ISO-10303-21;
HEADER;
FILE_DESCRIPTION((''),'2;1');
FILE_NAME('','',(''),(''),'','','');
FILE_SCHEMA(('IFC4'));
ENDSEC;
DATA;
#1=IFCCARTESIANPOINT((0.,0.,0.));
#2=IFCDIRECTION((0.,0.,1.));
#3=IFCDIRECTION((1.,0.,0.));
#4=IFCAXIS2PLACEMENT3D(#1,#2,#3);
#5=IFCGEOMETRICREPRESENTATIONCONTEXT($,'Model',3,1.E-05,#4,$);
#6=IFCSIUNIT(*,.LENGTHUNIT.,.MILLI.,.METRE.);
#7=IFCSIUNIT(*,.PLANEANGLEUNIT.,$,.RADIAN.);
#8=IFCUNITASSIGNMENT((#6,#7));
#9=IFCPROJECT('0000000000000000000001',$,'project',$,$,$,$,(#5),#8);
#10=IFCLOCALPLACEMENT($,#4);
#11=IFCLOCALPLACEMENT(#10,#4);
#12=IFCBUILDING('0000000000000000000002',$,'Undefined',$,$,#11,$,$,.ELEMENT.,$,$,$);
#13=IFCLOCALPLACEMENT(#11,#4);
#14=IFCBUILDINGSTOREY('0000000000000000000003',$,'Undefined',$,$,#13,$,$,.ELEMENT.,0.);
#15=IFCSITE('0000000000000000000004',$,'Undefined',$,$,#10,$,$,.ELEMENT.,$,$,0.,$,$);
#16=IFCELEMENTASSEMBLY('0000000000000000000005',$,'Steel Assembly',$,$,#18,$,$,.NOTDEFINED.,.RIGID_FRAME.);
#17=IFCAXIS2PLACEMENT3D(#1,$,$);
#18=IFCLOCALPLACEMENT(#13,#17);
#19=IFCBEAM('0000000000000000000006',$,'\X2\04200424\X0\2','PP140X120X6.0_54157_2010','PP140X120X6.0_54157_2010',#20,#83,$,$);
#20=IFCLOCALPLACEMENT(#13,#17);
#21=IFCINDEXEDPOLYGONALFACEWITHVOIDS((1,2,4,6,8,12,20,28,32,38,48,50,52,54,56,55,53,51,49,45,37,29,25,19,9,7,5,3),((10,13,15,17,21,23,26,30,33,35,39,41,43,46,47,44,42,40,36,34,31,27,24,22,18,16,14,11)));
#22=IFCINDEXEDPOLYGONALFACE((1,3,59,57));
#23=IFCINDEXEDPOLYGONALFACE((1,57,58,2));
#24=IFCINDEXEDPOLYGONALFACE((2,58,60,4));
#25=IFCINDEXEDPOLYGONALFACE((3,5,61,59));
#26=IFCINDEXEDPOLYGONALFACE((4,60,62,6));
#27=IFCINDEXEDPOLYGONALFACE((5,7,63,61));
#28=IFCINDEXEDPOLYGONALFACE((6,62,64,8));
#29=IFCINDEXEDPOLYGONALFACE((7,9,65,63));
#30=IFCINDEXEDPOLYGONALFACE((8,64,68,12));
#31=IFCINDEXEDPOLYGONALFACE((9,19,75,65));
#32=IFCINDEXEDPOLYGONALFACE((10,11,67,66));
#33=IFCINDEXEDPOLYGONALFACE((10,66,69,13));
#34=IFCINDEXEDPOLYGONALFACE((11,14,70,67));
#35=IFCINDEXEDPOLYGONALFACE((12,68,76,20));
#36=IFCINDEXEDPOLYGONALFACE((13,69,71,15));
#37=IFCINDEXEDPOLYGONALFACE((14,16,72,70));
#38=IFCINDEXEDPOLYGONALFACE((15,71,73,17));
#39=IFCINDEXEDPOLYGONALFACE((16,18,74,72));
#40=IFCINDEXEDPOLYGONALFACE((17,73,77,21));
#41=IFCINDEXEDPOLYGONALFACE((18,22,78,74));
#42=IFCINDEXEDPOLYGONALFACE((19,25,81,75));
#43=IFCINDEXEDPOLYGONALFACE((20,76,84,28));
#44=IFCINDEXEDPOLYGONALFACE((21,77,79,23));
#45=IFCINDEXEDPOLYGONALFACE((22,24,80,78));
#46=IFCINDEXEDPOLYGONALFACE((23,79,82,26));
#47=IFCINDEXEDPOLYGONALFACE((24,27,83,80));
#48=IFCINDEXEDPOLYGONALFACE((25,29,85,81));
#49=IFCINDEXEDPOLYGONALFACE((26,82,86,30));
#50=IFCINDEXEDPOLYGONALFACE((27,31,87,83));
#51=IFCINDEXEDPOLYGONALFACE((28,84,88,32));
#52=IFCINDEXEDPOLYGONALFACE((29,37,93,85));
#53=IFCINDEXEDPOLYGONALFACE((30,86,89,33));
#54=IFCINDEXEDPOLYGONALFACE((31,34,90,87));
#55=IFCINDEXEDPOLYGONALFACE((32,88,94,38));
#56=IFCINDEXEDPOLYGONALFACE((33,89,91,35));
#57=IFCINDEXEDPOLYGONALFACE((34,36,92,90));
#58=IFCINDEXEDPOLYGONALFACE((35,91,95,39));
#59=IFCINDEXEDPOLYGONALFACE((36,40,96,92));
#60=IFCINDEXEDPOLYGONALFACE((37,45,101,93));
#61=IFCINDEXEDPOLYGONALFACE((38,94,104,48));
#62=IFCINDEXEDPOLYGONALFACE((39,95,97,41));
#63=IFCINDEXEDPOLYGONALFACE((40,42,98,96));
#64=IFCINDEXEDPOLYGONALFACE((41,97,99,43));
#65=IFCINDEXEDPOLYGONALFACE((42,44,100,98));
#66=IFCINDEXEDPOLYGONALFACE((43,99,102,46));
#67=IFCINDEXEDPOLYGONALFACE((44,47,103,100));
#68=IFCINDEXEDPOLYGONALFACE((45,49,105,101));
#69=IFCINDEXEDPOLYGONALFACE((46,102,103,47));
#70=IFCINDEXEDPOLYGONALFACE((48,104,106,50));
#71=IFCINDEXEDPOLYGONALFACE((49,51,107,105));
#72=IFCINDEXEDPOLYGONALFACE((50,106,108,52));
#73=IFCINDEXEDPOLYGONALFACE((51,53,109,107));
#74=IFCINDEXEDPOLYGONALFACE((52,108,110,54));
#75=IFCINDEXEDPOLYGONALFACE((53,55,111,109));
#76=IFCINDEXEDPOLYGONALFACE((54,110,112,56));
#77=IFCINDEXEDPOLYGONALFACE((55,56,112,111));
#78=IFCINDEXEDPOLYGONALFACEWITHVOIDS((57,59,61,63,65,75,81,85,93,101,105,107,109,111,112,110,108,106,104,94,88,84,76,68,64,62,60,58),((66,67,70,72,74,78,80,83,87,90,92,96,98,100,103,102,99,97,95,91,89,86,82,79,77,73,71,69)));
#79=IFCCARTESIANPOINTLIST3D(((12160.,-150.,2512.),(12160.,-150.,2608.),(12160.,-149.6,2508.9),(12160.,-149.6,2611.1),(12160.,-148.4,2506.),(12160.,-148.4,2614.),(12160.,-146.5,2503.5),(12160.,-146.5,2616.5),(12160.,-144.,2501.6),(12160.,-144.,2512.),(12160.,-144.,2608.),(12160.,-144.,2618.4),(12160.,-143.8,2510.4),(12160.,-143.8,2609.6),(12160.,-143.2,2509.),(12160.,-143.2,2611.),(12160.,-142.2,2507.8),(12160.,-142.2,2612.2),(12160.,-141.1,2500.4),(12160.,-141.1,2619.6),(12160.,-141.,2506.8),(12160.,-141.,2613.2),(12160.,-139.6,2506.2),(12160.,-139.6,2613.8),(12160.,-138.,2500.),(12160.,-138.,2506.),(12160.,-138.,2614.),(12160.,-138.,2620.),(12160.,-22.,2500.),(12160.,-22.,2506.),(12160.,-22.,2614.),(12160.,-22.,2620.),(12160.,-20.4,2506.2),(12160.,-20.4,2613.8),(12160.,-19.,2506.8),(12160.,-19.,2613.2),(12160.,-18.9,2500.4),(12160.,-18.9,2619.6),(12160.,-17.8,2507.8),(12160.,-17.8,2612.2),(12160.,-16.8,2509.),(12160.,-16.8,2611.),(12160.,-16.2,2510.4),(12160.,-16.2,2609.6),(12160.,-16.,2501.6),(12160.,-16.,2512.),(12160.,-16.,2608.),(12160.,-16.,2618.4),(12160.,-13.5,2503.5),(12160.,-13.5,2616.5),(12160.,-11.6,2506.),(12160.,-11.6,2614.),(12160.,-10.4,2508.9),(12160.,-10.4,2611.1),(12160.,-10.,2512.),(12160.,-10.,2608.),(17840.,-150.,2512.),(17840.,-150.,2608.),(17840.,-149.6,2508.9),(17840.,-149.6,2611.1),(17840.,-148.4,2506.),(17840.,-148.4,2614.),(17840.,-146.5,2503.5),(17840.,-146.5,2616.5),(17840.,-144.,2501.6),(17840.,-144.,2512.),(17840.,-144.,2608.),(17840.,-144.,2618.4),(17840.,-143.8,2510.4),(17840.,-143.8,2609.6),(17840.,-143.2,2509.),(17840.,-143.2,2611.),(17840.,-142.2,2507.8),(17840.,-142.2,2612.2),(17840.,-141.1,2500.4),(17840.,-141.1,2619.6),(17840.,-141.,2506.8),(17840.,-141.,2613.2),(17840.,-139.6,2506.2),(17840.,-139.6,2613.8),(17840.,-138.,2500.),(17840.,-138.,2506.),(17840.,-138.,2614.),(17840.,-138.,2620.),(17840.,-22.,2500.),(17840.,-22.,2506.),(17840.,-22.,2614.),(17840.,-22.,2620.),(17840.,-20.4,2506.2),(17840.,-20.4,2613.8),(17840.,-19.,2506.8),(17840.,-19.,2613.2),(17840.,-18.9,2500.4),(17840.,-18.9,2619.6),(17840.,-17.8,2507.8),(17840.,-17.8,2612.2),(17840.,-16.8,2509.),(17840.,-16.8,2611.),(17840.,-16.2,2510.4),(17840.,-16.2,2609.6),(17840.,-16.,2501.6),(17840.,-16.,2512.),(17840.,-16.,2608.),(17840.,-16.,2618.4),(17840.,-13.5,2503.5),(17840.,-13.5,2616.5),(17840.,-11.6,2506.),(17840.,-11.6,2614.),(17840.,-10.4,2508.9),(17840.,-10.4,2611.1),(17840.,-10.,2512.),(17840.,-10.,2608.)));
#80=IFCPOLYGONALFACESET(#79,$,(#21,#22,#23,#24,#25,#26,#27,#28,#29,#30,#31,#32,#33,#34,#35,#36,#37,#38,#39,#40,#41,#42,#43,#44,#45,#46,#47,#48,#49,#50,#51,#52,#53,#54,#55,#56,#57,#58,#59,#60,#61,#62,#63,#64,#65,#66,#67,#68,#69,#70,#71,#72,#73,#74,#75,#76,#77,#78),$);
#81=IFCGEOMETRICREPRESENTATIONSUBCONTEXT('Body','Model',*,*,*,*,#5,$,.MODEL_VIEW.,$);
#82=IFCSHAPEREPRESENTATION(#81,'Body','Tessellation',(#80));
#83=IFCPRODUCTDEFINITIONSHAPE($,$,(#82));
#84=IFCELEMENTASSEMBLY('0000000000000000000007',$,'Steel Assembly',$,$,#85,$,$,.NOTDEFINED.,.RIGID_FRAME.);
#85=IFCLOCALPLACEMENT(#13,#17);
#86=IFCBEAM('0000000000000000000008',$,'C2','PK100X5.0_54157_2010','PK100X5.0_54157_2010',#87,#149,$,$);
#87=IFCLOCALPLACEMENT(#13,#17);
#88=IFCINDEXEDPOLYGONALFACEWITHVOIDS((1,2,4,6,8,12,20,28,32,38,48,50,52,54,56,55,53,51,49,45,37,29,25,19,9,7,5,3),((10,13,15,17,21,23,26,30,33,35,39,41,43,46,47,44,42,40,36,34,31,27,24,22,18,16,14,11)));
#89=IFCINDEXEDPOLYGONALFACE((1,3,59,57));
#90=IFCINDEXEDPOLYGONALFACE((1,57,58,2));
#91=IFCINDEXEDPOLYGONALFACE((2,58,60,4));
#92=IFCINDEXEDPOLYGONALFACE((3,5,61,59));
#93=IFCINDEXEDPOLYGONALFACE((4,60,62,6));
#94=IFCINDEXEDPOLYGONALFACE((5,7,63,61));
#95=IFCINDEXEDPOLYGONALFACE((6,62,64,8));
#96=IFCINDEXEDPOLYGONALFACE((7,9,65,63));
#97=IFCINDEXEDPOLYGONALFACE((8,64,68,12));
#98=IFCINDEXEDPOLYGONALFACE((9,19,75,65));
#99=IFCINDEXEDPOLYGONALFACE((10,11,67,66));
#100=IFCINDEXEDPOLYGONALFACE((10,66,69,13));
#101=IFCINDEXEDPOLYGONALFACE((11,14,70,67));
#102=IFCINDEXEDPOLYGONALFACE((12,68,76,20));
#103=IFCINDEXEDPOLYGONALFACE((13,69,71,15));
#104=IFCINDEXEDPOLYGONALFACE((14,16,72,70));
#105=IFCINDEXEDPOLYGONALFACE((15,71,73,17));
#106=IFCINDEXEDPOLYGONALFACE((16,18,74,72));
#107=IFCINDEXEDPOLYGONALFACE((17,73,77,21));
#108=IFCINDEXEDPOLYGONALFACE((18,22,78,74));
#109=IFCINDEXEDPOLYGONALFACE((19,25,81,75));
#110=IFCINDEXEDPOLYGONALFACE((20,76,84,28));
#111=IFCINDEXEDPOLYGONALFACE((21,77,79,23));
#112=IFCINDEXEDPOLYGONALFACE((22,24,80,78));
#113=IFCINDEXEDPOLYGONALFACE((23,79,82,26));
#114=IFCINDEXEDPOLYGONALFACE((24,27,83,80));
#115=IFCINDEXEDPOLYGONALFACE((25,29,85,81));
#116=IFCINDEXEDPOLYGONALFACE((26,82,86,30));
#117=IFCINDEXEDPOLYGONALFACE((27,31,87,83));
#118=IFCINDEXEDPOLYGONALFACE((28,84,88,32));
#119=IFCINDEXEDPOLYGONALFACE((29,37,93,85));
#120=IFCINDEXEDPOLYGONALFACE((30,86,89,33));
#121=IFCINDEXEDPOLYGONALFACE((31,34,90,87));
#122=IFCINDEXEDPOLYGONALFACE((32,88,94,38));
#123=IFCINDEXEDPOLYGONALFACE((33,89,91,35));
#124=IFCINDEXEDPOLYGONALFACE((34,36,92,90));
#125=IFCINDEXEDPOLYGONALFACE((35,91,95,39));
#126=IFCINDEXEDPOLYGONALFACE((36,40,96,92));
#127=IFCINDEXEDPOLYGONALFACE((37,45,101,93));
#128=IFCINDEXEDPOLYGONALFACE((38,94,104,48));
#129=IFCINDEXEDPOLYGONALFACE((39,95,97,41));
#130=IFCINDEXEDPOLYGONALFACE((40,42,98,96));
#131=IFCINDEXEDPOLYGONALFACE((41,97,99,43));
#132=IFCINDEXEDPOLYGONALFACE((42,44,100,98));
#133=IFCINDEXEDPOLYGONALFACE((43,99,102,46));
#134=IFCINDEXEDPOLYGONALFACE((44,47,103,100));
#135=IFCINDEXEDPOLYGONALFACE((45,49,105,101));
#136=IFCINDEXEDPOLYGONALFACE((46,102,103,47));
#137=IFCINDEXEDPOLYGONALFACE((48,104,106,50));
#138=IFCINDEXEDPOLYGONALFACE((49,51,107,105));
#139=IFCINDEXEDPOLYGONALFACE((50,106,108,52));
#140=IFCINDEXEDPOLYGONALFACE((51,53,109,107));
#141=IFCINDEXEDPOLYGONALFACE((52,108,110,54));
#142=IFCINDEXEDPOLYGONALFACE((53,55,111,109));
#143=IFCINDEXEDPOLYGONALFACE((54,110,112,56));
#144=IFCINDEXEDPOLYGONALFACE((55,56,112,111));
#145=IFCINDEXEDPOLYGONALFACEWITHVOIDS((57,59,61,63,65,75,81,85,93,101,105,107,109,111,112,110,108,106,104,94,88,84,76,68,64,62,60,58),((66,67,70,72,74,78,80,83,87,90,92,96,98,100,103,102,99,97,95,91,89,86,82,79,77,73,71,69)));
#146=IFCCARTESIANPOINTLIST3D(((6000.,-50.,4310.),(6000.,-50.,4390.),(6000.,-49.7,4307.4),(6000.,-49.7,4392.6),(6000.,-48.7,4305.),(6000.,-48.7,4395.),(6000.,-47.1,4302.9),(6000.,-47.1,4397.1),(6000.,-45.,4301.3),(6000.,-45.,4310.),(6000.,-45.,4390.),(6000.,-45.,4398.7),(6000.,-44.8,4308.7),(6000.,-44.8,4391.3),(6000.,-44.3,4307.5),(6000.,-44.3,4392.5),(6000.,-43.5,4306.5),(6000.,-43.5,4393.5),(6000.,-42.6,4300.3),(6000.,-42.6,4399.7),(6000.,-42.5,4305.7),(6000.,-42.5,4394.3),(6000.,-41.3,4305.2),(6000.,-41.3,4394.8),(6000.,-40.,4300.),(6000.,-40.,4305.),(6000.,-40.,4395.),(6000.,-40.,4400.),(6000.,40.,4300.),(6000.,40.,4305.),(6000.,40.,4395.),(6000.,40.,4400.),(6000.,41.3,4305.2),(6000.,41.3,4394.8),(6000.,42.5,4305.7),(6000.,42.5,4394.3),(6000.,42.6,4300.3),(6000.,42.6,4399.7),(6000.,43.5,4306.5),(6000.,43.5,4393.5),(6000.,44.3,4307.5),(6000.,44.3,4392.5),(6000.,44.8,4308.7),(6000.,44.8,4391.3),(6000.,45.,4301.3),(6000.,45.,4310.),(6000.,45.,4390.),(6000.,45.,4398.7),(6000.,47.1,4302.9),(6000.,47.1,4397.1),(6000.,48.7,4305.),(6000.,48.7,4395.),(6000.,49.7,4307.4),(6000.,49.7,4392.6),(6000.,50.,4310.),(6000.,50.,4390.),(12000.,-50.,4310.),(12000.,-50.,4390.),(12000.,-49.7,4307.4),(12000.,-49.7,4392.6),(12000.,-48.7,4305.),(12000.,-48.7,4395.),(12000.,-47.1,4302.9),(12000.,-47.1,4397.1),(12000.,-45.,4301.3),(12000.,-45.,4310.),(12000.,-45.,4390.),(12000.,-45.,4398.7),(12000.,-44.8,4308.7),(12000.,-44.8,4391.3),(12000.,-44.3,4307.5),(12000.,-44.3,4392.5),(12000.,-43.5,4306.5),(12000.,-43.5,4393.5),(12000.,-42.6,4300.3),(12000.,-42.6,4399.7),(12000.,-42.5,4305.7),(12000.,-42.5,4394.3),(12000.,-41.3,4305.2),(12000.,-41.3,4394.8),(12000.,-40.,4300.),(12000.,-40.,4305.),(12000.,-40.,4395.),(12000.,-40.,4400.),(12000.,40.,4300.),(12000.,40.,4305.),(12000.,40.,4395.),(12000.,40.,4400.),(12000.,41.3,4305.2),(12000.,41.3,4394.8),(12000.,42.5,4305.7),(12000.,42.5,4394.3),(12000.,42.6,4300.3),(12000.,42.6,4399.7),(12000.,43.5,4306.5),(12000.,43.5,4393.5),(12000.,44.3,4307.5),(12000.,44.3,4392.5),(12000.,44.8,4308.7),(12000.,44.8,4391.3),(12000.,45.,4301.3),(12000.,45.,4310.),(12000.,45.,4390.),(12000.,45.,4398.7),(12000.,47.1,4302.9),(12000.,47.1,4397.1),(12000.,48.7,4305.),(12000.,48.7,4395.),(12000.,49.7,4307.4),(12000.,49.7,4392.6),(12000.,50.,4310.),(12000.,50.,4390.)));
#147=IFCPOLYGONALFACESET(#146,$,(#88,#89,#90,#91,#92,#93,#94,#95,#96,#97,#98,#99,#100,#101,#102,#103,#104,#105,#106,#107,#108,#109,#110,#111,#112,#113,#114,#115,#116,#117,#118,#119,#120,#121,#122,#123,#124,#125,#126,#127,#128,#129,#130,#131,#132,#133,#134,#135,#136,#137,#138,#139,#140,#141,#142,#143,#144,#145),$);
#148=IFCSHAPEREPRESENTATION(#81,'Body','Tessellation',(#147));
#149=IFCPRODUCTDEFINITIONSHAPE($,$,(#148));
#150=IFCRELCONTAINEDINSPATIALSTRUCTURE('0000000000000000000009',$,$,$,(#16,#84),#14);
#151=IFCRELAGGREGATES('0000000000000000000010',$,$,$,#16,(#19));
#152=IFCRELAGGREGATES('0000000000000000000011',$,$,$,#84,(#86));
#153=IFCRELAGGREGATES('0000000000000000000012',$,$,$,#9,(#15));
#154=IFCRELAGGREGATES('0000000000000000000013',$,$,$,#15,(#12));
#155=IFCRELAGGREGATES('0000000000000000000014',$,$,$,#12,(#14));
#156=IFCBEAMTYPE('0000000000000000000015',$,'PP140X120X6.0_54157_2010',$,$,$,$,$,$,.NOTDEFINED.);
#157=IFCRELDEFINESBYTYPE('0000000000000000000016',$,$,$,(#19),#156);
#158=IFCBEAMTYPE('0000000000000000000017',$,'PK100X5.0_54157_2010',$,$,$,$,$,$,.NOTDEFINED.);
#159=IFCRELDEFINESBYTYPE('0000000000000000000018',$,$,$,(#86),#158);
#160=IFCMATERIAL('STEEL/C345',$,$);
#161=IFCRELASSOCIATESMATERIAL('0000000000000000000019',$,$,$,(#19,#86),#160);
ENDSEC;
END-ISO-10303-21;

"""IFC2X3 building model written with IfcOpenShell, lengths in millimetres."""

from ifc_helpers import new_model, si_unit, frame, origin_with_axes, origin_2d_with_axis, place, context, subcontext, project, spatial, hollow_rectangle, extrude, material, type_object, element, aggregate, save


model = new_model("IFC2X3")

# Units and contexts
model_context = context("Model", 3, precision=1e-05, world=origin_with_axes())
body_context = subcontext(model_context, "Body", "Model", "MODEL_VIEW")
ifc_project = project(units=[si_unit("LENGTHUNIT", "METRE", prefix="MILLI"), si_unit("PLANEANGLEUNIT", "RADIAN")], contexts=[model_context])

# Site, building, storey
site_placement = place(None, origin_with_axes())
site = spatial("IfcSite", under=ifc_project, at=site_placement, Name="Undefined", CompositionType="ELEMENT", RefElevation=0.0)
building_placement = place(site_placement, origin_with_axes())
building = spatial("IfcBuilding", under=site, at=building_placement, Name="Undefined", CompositionType="ELEMENT")
storey_placement = place(building_placement, origin_with_axes())
storey = spatial("IfcBuildingStorey", under=building, at=storey_placement, Name="Undefined", CompositionType="ELEMENT", Elevation=0.0)

# Shared definitions
ifc_material_1 = material(Name="STEEL/C345")

# Element assemblies, beams
beam_type_1 = type_object("IfcBeamType", Name="PP140X120X6.0_54157_2010", PredefinedType="NOTDEFINED")
assembly_1_placement = place(storey_placement, origin_with_axes())
assembly_1 = element("IfcElementAssembly", 1, at=assembly_1_placement, inside=storey, Name="Steel Assembly", AssemblyPlace="NOTDEFINED", PredefinedType="RIGID_FRAME")
beam_1_placement = place(assembly_1_placement, frame((17840.0, -80.0, 2560.0), z_axis=(0.0, 1.0, 0.0), x_axis=(-1.0, 0.0, 0.0)))
beam_1 = element("IfcBeam", 2, at=beam_1_placement, type_object=beam_type_1, material=ifc_material_1, Name="РФ2", Description="PP140X120X6.0_54157_2010", ObjectType="PP140X120X6.0_54157_2010", context=body_context, shape_type="SweptSolid", body=[
    extrude(hollow_rectangle(XDim=120.0, YDim=140.0, WallThickness=6.0, InnerFilletRadius=6.0, OuterFilletRadius=12.0, at=origin_2d_with_axis()), frame((5680.0, 0.0, 0.0), z_axis=(-1.0, 0.0, 0.0), x_axis=(0.0, -1.0, 0.0)), (0.0, 0.0, 1.0), 5680.0),
])
aggregate(assembly_1, [beam_1])
assembly_2_placement = place(storey_placement, origin_with_axes())
assembly_2 = element("IfcElementAssembly", 3, at=assembly_2_placement, inside=storey, Name="Steel Assembly", AssemblyPlace="NOTDEFINED", PredefinedType="RIGID_FRAME")
beam_type_2 = type_object("IfcBeamType", Name="PK100X5.0_54157_2010", PredefinedType="NOTDEFINED")
beam_2_placement = place(assembly_2_placement, frame((12000.0, 0.0, 4350.0), z_axis=(0.0, 0.0, 1.0), x_axis=(-1.0, 0.0, 0.0)))
beam_2 = element("IfcBeam", 4, at=beam_2_placement, type_object=beam_type_2, material=ifc_material_1, Name="C2", Description="PK100X5.0_54157_2010", ObjectType="PK100X5.0_54157_2010", context=body_context, shape_type="SweptSolid", body=[
    extrude(hollow_rectangle(XDim=100.0, YDim=100.0, WallThickness=5.0, InnerFilletRadius=5.0, OuterFilletRadius=10.0, at=origin_2d_with_axis()), frame((6000.0, 0.0, 0.0), z_axis=(-1.0, 0.0, 0.0), x_axis=(0.0, -1.0, 0.0)), (0.0, 0.0, 1.0), 6000.0),
])
aggregate(assembly_2, [beam_2])

save(model, "model.ifc")
